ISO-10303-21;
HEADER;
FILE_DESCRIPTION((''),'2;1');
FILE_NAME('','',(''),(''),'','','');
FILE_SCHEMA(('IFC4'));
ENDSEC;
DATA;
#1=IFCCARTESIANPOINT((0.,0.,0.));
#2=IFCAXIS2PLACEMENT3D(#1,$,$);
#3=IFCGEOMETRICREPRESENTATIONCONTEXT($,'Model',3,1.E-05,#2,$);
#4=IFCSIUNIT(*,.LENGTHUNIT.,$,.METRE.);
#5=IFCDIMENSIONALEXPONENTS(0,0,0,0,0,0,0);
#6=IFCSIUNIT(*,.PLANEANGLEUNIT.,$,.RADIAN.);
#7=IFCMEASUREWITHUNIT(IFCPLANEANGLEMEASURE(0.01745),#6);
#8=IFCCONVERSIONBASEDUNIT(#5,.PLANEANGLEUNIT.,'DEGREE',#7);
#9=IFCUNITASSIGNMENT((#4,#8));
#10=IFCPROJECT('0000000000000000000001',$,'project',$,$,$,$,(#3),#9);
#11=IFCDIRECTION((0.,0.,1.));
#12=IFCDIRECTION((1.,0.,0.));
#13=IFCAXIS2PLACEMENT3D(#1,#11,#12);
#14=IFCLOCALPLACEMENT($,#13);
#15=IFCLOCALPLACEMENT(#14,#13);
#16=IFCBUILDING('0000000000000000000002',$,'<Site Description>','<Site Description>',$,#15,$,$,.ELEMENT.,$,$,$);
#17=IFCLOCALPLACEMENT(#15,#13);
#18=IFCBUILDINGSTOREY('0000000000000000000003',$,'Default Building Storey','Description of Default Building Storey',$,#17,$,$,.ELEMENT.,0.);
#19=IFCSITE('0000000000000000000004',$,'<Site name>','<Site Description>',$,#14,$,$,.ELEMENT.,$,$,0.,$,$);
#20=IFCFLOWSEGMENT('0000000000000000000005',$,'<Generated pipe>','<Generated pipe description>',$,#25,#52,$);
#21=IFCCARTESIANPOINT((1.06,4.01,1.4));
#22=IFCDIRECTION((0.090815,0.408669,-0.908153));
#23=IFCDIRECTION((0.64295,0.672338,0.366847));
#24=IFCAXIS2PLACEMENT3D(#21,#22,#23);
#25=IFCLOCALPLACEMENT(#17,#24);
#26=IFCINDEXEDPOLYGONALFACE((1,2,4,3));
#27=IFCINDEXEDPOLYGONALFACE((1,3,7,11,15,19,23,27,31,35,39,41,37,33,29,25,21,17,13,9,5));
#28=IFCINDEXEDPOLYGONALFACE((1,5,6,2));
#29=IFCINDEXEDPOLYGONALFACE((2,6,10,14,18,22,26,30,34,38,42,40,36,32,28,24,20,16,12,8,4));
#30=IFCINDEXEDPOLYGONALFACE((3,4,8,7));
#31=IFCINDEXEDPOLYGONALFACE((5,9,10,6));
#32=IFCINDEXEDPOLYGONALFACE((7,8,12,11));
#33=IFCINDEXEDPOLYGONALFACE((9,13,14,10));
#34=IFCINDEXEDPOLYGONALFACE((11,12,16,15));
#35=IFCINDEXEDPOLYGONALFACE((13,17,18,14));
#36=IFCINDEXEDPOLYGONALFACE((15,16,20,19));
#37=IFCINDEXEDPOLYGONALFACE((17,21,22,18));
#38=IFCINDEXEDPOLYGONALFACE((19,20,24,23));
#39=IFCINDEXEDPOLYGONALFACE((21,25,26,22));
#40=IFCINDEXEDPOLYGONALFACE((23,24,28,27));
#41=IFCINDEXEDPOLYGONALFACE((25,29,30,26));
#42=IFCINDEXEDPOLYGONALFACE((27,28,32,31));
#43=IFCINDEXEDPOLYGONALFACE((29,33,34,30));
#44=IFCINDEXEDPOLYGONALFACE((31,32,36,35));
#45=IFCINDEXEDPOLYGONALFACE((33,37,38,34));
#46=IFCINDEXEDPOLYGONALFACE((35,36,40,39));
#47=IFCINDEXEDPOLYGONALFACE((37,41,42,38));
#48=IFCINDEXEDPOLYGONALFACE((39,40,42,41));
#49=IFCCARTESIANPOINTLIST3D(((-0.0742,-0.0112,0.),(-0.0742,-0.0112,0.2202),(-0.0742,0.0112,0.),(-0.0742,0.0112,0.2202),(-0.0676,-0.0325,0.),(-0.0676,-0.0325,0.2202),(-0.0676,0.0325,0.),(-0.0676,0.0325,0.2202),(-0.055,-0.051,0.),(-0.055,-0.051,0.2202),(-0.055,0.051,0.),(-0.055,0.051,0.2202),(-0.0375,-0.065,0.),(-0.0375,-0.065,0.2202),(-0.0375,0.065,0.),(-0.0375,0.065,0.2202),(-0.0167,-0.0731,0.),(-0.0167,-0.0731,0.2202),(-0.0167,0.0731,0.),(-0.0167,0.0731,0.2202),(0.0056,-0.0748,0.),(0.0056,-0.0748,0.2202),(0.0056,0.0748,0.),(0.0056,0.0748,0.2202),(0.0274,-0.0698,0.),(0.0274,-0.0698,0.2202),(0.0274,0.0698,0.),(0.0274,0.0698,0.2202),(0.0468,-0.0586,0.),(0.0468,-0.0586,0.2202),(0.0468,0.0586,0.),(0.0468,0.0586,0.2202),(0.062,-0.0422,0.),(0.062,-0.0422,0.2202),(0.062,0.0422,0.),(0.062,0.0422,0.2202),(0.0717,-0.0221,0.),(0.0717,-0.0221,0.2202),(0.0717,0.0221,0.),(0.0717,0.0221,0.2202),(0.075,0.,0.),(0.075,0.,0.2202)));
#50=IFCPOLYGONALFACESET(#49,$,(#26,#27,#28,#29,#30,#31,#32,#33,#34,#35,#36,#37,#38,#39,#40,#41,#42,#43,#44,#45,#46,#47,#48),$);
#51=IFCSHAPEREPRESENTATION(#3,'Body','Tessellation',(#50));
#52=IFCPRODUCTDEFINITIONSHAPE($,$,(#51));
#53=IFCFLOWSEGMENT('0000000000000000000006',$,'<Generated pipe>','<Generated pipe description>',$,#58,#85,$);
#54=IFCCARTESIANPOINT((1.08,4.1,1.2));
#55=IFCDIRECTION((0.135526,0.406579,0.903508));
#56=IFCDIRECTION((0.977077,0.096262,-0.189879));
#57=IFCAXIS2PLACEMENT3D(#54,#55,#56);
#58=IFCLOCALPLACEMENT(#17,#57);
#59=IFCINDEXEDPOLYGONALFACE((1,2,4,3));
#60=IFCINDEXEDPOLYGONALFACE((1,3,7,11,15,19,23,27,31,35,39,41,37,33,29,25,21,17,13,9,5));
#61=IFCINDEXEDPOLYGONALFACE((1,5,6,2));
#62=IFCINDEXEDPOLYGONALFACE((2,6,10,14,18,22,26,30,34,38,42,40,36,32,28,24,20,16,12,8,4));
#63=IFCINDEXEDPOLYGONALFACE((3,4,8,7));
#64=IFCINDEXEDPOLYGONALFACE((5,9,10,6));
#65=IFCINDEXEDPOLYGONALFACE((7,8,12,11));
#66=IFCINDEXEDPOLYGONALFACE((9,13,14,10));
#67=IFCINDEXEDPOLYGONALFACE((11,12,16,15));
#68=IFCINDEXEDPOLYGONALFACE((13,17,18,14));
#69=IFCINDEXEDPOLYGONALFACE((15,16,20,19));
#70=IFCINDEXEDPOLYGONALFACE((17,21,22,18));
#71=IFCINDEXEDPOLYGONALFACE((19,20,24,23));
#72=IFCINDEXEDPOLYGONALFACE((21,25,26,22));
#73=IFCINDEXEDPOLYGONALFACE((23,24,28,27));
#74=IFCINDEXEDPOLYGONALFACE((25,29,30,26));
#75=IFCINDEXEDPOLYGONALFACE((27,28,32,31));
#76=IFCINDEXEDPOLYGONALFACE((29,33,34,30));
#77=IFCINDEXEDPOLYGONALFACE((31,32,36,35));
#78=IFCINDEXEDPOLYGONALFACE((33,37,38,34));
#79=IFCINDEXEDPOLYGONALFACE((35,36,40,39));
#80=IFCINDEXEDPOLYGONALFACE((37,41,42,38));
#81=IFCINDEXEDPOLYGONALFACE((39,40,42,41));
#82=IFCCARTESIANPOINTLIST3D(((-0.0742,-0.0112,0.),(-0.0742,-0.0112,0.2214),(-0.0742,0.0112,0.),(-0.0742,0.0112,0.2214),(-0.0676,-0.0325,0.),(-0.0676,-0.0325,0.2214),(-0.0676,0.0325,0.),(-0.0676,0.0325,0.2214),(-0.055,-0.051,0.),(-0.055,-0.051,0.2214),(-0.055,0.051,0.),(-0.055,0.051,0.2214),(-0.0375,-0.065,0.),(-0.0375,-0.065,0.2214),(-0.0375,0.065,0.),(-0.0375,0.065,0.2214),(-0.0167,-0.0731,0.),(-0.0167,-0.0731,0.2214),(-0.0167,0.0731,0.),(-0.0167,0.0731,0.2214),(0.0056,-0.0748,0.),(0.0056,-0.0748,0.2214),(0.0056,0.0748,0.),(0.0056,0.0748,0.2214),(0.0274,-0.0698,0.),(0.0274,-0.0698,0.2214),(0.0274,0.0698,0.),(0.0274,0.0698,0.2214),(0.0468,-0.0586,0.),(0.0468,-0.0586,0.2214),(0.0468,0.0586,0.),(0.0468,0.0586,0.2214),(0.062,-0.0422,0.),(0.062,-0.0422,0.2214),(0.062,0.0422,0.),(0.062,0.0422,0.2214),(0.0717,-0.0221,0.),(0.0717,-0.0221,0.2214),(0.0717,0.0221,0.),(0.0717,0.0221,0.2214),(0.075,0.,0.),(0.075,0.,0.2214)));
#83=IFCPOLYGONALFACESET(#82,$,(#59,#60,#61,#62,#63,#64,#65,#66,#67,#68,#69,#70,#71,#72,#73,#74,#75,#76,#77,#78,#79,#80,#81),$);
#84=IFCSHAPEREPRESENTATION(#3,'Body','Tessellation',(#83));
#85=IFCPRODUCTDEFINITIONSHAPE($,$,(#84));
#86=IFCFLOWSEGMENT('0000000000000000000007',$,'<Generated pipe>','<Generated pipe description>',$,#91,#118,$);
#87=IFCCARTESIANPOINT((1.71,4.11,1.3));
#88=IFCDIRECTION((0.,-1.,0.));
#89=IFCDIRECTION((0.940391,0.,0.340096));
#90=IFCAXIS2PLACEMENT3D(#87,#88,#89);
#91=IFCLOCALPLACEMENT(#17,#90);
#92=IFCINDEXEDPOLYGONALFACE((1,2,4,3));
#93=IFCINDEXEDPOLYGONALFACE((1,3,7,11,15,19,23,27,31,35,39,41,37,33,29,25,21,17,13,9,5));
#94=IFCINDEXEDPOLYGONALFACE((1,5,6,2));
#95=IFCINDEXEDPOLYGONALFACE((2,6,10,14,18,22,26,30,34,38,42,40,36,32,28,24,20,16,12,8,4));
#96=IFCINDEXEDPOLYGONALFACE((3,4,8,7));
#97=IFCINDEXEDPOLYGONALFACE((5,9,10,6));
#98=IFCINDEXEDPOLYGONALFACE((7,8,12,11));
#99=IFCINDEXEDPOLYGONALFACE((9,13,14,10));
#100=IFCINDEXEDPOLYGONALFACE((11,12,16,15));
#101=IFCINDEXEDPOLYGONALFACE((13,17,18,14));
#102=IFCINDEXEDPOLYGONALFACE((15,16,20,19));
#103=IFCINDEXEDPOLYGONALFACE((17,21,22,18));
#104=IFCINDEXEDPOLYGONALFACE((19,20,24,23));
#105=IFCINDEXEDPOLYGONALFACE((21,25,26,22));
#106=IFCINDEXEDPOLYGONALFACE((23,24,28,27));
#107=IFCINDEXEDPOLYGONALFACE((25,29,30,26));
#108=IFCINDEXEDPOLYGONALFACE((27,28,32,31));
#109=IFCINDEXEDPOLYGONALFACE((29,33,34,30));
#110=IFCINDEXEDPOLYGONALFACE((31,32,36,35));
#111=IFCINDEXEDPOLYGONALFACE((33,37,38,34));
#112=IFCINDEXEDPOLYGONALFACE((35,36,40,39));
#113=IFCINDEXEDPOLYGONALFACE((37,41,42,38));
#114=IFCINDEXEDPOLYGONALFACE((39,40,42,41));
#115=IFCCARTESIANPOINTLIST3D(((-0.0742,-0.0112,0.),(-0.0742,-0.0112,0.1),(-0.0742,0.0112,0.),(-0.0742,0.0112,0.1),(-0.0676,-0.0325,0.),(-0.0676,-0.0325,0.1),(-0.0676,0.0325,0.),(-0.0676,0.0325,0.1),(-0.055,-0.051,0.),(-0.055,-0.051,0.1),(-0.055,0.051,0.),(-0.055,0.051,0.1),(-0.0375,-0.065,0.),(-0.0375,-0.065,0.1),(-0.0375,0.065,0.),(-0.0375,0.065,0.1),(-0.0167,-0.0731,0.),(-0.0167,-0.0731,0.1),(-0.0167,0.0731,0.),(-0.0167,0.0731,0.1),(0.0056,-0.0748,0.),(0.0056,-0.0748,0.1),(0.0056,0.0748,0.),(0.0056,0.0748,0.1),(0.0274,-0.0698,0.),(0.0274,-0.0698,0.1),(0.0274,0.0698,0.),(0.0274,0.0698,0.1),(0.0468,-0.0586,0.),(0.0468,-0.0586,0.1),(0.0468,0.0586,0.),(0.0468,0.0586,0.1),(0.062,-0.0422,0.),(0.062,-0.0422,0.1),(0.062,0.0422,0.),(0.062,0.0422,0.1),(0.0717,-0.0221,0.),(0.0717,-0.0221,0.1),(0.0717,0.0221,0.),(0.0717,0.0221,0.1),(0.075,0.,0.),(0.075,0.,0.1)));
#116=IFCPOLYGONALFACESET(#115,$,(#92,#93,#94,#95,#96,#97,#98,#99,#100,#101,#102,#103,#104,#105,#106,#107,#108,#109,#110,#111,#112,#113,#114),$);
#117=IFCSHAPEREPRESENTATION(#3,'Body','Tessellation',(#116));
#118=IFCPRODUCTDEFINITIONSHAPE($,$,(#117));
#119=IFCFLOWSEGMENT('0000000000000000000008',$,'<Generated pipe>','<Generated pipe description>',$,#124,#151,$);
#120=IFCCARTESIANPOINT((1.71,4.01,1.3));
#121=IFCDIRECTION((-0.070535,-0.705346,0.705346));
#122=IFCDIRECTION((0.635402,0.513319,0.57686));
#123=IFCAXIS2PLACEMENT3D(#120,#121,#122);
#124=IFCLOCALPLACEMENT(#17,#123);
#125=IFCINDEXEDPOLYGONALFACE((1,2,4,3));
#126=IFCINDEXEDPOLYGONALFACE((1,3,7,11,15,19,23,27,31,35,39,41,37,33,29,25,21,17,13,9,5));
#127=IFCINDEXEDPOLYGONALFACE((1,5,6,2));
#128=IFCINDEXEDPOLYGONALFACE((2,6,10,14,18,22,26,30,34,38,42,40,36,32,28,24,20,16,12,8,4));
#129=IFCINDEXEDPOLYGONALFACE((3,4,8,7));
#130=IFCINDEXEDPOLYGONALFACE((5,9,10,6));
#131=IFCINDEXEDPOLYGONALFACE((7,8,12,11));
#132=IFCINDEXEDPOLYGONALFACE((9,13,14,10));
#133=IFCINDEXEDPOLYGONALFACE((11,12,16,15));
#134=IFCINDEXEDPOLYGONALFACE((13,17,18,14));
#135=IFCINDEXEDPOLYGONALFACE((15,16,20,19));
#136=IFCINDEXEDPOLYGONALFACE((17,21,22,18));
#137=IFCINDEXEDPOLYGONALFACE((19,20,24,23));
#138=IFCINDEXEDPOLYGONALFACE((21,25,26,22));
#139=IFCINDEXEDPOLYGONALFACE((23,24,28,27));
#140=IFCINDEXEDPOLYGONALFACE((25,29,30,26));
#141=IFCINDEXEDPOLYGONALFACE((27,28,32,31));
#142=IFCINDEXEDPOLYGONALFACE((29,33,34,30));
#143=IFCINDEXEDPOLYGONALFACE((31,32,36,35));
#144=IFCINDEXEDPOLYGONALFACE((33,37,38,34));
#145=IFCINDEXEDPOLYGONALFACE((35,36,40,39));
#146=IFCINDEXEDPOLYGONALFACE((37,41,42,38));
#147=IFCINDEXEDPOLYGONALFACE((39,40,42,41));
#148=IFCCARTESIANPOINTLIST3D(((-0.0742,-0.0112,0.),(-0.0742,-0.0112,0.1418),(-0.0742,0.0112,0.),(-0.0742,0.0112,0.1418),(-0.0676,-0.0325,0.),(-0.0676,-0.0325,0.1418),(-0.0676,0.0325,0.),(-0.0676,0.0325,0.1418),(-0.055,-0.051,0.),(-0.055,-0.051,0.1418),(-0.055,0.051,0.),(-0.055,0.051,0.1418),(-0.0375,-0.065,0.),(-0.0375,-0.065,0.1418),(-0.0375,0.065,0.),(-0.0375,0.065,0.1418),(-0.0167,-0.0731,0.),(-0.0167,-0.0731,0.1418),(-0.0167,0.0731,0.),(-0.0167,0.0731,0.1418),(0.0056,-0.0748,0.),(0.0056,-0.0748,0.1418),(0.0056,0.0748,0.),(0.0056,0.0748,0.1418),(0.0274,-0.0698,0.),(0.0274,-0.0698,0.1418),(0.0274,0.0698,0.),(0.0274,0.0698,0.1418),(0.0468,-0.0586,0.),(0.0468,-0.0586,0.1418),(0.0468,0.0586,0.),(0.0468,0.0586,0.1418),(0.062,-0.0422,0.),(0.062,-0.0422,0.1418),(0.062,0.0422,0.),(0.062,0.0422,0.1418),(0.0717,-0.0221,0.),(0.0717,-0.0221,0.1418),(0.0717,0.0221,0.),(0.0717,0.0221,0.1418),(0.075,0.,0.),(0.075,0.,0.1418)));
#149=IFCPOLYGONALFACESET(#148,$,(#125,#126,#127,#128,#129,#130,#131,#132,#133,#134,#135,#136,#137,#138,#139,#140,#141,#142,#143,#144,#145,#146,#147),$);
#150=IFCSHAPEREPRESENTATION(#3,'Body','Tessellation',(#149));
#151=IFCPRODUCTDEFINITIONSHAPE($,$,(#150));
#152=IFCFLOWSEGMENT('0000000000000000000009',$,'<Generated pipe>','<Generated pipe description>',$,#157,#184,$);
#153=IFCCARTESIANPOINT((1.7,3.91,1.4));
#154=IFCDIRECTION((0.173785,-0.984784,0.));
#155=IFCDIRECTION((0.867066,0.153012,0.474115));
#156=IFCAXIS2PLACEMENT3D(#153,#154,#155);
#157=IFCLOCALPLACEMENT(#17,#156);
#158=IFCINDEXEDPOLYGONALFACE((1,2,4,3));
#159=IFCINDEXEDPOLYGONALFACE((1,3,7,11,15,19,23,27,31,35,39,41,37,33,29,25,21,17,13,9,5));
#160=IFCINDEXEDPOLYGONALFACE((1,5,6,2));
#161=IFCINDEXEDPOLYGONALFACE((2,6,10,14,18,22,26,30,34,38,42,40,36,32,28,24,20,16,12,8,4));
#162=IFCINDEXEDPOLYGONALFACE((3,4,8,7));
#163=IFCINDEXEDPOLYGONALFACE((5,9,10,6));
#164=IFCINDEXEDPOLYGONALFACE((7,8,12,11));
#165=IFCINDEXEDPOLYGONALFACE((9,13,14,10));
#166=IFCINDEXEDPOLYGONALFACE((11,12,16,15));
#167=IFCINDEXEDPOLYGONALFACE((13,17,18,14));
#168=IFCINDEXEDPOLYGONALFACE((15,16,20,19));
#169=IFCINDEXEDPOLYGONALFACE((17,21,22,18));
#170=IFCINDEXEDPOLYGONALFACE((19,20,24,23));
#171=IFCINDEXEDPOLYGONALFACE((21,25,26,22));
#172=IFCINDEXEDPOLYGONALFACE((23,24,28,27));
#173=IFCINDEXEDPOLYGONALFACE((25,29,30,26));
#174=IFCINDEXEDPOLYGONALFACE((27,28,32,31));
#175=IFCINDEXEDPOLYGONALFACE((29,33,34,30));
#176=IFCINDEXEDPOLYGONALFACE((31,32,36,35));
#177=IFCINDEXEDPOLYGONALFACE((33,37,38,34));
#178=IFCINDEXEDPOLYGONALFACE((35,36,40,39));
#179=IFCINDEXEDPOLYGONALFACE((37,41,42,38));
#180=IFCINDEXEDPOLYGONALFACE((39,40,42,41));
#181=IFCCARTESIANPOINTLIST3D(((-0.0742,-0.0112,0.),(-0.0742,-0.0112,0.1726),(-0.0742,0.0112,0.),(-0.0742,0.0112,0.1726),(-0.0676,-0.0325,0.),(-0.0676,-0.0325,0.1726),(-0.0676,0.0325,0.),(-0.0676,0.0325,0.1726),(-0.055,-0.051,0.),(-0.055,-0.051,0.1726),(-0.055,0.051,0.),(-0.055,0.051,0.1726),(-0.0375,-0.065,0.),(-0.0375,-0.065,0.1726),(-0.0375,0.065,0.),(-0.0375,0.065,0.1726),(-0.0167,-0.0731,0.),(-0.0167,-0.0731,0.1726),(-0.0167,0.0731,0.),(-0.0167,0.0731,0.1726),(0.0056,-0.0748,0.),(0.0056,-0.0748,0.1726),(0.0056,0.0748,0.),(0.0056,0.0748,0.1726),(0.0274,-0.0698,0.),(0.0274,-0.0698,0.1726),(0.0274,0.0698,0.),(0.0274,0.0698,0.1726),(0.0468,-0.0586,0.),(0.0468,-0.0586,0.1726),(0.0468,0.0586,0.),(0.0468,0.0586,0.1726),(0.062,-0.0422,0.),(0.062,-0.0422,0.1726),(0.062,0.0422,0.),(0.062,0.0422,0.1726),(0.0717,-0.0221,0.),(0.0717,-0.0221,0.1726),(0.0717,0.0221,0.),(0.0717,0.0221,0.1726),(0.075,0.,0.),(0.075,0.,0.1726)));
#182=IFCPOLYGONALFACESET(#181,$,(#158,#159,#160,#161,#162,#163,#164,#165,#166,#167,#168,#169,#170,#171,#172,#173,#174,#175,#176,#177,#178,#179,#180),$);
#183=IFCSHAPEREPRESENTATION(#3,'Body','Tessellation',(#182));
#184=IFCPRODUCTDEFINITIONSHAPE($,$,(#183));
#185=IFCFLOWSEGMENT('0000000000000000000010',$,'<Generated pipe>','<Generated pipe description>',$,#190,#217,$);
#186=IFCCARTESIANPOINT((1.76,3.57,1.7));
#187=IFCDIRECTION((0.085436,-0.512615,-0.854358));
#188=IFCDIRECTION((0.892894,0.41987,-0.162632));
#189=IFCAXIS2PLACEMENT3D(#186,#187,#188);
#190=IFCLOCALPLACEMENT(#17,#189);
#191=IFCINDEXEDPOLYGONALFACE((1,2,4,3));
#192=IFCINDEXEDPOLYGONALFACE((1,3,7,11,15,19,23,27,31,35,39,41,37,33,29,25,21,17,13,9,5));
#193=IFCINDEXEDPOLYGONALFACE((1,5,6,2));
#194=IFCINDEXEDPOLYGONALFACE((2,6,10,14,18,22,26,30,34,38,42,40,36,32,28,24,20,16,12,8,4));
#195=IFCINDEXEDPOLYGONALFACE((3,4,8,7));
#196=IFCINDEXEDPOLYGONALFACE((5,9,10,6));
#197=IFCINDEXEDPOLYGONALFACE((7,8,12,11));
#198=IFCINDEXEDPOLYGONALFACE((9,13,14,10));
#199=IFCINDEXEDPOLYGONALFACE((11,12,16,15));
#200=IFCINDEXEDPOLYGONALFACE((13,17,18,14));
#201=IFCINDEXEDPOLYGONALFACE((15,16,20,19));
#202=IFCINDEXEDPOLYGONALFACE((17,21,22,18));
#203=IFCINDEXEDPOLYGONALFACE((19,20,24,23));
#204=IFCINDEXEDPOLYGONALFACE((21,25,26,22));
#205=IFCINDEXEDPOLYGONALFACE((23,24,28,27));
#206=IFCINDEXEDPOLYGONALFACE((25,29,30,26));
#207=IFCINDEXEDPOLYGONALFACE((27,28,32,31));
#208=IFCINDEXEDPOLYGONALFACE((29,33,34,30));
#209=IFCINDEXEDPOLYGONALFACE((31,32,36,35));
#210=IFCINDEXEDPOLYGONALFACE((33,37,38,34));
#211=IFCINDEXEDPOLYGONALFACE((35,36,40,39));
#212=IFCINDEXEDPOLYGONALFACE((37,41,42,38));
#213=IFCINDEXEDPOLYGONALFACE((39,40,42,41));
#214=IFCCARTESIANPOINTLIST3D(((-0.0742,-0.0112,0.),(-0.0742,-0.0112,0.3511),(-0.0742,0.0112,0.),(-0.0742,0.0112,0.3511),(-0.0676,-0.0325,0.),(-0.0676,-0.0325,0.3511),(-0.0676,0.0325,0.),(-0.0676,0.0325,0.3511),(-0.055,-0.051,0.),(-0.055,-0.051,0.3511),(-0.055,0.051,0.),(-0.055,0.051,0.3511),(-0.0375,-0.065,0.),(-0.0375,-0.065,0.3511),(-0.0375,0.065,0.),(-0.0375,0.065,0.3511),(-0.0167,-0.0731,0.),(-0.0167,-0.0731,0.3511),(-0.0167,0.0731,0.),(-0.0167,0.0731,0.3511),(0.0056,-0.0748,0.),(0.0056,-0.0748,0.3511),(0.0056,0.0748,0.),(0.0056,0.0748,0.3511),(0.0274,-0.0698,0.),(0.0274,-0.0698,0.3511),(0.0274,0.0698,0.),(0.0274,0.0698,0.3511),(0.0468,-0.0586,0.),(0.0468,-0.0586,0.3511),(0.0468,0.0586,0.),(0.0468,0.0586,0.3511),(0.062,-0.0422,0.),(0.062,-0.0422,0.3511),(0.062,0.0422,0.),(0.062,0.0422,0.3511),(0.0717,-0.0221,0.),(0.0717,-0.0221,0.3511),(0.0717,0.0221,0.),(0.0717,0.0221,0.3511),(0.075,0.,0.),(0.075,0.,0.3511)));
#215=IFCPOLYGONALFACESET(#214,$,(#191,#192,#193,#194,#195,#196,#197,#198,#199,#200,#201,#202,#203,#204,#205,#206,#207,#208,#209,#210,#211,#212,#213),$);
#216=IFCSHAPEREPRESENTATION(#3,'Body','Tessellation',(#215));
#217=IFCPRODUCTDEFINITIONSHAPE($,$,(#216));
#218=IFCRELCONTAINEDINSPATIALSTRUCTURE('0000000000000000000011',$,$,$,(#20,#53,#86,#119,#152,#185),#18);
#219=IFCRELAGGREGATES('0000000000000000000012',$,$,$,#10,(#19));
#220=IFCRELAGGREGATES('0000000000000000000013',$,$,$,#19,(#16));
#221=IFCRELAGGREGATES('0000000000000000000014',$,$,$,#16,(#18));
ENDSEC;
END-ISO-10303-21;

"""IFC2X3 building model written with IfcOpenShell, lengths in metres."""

from ifc_helpers import new_model, entity, si_unit, converted_unit, frame, origin, origin_with_axes, origin_2d_with_axis, place, context, project, spatial, circle, extrude, element, save


model = new_model("IFC2X3")

# Units and contexts
model_context = context("Model", 3, precision=1e-05, world=origin())
ifc_project = project(units=[si_unit("LENGTHUNIT", "METRE"), converted_unit("PLANEANGLEUNIT", "DEGREE", entity("IfcPlaneAngleMeasure", 0.01745), si_unit("PLANEANGLEUNIT", "RADIAN"), dimensions=[0, 0, 0, 0, 0, 0, 0])], contexts=[model_context])

# Site, building, storey
site_placement = place(None, origin_with_axes())
site = spatial("IfcSite", under=ifc_project, at=site_placement, Name="<Site name>", Description="<Site Description>", CompositionType="ELEMENT", RefElevation=0.0)
building_placement = place(site_placement, origin_with_axes())
building = spatial("IfcBuilding", under=site, at=building_placement, Name="<Site Description>", Description="<Site Description>", CompositionType="ELEMENT")
storey_placement = place(building_placement, origin_with_axes())
storey = spatial("IfcBuildingStorey", under=building, at=storey_placement, Name="Default Building Storey", Description="Description of Default Building Storey", CompositionType="ELEMENT", Elevation=0.0)

# Flow segments
flow_segment_1_placement = place(storey_placement, frame((1.06, 4.01, 1.4), z_axis=(0.090815, 0.408669, -0.908153), x_axis=(0.64295, 0.672338, 0.366847)))
element("IfcFlowSegment", 1, at=flow_segment_1_placement, inside=storey, Name="<Generated pipe>", Description="<Generated pipe description>", context=model_context, shape_type="SweptSolid", body=[
    extrude(circle(Radius=0.075, at=origin_2d_with_axis()), origin_with_axes(), (0.0, 0.0, 1.0), 0.2202),
])
flow_segment_2_placement = place(storey_placement, frame((1.08, 4.1, 1.2), z_axis=(0.135526, 0.406579, 0.903508), x_axis=(0.977077, 0.096262, -0.189879)))
element("IfcFlowSegment", 2, at=flow_segment_2_placement, inside=storey, Name="<Generated pipe>", Description="<Generated pipe description>", context=model_context, shape_type="SweptSolid", body=[
    extrude(circle(Radius=0.075, at=origin_2d_with_axis()), origin_with_axes(), (0.0, 0.0, 1.0), 0.2214),
])
flow_segment_3_placement = place(storey_placement, frame((1.71, 4.11, 1.3), z_axis=(0.0, -1.0, 0.0), x_axis=(0.940391, 0.0, 0.340096)))
element("IfcFlowSegment", 3, at=flow_segment_3_placement, inside=storey, Name="<Generated pipe>", Description="<Generated pipe description>", context=model_context, shape_type="SweptSolid", body=[
    extrude(circle(Radius=0.075, at=origin_2d_with_axis()), origin_with_axes(), (0.0, 0.0, 1.0), 0.1),
])
flow_segment_4_placement = place(storey_placement, frame((1.71, 4.01, 1.3), z_axis=(-0.070535, -0.705346, 0.705346), x_axis=(0.635402, 0.513319, 0.57686)))
element("IfcFlowSegment", 4, at=flow_segment_4_placement, inside=storey, Name="<Generated pipe>", Description="<Generated pipe description>", context=model_context, shape_type="SweptSolid", body=[
    extrude(circle(Radius=0.075, at=origin_2d_with_axis()), origin_with_axes(), (0.0, 0.0, 1.0), 0.1418),
])
flow_segment_5_placement = place(storey_placement, frame((1.7, 3.91, 1.4), z_axis=(0.173785, -0.984784, 0.0), x_axis=(0.867066, 0.153012, 0.474115)))
element("IfcFlowSegment", 5, at=flow_segment_5_placement, inside=storey, Name="<Generated pipe>", Description="<Generated pipe description>", context=model_context, shape_type="SweptSolid", body=[
    extrude(circle(Radius=0.075, at=origin_2d_with_axis()), origin_with_axes(), (0.0, 0.0, 1.0), 0.1726),
])
flow_segment_6_placement = place(storey_placement, frame((1.76, 3.57, 1.7), z_axis=(0.085436, -0.512615, -0.854358), x_axis=(0.892894, 0.41987, -0.162632)))
element("IfcFlowSegment", 6, at=flow_segment_6_placement, inside=storey, Name="<Generated pipe>", Description="<Generated pipe description>", context=model_context, shape_type="SweptSolid", body=[
    extrude(circle(Radius=0.075, at=origin_2d_with_axis()), origin_with_axes(), (0.0, 0.0, 1.0), 0.3511),
])

save(model, "model.ifc")
